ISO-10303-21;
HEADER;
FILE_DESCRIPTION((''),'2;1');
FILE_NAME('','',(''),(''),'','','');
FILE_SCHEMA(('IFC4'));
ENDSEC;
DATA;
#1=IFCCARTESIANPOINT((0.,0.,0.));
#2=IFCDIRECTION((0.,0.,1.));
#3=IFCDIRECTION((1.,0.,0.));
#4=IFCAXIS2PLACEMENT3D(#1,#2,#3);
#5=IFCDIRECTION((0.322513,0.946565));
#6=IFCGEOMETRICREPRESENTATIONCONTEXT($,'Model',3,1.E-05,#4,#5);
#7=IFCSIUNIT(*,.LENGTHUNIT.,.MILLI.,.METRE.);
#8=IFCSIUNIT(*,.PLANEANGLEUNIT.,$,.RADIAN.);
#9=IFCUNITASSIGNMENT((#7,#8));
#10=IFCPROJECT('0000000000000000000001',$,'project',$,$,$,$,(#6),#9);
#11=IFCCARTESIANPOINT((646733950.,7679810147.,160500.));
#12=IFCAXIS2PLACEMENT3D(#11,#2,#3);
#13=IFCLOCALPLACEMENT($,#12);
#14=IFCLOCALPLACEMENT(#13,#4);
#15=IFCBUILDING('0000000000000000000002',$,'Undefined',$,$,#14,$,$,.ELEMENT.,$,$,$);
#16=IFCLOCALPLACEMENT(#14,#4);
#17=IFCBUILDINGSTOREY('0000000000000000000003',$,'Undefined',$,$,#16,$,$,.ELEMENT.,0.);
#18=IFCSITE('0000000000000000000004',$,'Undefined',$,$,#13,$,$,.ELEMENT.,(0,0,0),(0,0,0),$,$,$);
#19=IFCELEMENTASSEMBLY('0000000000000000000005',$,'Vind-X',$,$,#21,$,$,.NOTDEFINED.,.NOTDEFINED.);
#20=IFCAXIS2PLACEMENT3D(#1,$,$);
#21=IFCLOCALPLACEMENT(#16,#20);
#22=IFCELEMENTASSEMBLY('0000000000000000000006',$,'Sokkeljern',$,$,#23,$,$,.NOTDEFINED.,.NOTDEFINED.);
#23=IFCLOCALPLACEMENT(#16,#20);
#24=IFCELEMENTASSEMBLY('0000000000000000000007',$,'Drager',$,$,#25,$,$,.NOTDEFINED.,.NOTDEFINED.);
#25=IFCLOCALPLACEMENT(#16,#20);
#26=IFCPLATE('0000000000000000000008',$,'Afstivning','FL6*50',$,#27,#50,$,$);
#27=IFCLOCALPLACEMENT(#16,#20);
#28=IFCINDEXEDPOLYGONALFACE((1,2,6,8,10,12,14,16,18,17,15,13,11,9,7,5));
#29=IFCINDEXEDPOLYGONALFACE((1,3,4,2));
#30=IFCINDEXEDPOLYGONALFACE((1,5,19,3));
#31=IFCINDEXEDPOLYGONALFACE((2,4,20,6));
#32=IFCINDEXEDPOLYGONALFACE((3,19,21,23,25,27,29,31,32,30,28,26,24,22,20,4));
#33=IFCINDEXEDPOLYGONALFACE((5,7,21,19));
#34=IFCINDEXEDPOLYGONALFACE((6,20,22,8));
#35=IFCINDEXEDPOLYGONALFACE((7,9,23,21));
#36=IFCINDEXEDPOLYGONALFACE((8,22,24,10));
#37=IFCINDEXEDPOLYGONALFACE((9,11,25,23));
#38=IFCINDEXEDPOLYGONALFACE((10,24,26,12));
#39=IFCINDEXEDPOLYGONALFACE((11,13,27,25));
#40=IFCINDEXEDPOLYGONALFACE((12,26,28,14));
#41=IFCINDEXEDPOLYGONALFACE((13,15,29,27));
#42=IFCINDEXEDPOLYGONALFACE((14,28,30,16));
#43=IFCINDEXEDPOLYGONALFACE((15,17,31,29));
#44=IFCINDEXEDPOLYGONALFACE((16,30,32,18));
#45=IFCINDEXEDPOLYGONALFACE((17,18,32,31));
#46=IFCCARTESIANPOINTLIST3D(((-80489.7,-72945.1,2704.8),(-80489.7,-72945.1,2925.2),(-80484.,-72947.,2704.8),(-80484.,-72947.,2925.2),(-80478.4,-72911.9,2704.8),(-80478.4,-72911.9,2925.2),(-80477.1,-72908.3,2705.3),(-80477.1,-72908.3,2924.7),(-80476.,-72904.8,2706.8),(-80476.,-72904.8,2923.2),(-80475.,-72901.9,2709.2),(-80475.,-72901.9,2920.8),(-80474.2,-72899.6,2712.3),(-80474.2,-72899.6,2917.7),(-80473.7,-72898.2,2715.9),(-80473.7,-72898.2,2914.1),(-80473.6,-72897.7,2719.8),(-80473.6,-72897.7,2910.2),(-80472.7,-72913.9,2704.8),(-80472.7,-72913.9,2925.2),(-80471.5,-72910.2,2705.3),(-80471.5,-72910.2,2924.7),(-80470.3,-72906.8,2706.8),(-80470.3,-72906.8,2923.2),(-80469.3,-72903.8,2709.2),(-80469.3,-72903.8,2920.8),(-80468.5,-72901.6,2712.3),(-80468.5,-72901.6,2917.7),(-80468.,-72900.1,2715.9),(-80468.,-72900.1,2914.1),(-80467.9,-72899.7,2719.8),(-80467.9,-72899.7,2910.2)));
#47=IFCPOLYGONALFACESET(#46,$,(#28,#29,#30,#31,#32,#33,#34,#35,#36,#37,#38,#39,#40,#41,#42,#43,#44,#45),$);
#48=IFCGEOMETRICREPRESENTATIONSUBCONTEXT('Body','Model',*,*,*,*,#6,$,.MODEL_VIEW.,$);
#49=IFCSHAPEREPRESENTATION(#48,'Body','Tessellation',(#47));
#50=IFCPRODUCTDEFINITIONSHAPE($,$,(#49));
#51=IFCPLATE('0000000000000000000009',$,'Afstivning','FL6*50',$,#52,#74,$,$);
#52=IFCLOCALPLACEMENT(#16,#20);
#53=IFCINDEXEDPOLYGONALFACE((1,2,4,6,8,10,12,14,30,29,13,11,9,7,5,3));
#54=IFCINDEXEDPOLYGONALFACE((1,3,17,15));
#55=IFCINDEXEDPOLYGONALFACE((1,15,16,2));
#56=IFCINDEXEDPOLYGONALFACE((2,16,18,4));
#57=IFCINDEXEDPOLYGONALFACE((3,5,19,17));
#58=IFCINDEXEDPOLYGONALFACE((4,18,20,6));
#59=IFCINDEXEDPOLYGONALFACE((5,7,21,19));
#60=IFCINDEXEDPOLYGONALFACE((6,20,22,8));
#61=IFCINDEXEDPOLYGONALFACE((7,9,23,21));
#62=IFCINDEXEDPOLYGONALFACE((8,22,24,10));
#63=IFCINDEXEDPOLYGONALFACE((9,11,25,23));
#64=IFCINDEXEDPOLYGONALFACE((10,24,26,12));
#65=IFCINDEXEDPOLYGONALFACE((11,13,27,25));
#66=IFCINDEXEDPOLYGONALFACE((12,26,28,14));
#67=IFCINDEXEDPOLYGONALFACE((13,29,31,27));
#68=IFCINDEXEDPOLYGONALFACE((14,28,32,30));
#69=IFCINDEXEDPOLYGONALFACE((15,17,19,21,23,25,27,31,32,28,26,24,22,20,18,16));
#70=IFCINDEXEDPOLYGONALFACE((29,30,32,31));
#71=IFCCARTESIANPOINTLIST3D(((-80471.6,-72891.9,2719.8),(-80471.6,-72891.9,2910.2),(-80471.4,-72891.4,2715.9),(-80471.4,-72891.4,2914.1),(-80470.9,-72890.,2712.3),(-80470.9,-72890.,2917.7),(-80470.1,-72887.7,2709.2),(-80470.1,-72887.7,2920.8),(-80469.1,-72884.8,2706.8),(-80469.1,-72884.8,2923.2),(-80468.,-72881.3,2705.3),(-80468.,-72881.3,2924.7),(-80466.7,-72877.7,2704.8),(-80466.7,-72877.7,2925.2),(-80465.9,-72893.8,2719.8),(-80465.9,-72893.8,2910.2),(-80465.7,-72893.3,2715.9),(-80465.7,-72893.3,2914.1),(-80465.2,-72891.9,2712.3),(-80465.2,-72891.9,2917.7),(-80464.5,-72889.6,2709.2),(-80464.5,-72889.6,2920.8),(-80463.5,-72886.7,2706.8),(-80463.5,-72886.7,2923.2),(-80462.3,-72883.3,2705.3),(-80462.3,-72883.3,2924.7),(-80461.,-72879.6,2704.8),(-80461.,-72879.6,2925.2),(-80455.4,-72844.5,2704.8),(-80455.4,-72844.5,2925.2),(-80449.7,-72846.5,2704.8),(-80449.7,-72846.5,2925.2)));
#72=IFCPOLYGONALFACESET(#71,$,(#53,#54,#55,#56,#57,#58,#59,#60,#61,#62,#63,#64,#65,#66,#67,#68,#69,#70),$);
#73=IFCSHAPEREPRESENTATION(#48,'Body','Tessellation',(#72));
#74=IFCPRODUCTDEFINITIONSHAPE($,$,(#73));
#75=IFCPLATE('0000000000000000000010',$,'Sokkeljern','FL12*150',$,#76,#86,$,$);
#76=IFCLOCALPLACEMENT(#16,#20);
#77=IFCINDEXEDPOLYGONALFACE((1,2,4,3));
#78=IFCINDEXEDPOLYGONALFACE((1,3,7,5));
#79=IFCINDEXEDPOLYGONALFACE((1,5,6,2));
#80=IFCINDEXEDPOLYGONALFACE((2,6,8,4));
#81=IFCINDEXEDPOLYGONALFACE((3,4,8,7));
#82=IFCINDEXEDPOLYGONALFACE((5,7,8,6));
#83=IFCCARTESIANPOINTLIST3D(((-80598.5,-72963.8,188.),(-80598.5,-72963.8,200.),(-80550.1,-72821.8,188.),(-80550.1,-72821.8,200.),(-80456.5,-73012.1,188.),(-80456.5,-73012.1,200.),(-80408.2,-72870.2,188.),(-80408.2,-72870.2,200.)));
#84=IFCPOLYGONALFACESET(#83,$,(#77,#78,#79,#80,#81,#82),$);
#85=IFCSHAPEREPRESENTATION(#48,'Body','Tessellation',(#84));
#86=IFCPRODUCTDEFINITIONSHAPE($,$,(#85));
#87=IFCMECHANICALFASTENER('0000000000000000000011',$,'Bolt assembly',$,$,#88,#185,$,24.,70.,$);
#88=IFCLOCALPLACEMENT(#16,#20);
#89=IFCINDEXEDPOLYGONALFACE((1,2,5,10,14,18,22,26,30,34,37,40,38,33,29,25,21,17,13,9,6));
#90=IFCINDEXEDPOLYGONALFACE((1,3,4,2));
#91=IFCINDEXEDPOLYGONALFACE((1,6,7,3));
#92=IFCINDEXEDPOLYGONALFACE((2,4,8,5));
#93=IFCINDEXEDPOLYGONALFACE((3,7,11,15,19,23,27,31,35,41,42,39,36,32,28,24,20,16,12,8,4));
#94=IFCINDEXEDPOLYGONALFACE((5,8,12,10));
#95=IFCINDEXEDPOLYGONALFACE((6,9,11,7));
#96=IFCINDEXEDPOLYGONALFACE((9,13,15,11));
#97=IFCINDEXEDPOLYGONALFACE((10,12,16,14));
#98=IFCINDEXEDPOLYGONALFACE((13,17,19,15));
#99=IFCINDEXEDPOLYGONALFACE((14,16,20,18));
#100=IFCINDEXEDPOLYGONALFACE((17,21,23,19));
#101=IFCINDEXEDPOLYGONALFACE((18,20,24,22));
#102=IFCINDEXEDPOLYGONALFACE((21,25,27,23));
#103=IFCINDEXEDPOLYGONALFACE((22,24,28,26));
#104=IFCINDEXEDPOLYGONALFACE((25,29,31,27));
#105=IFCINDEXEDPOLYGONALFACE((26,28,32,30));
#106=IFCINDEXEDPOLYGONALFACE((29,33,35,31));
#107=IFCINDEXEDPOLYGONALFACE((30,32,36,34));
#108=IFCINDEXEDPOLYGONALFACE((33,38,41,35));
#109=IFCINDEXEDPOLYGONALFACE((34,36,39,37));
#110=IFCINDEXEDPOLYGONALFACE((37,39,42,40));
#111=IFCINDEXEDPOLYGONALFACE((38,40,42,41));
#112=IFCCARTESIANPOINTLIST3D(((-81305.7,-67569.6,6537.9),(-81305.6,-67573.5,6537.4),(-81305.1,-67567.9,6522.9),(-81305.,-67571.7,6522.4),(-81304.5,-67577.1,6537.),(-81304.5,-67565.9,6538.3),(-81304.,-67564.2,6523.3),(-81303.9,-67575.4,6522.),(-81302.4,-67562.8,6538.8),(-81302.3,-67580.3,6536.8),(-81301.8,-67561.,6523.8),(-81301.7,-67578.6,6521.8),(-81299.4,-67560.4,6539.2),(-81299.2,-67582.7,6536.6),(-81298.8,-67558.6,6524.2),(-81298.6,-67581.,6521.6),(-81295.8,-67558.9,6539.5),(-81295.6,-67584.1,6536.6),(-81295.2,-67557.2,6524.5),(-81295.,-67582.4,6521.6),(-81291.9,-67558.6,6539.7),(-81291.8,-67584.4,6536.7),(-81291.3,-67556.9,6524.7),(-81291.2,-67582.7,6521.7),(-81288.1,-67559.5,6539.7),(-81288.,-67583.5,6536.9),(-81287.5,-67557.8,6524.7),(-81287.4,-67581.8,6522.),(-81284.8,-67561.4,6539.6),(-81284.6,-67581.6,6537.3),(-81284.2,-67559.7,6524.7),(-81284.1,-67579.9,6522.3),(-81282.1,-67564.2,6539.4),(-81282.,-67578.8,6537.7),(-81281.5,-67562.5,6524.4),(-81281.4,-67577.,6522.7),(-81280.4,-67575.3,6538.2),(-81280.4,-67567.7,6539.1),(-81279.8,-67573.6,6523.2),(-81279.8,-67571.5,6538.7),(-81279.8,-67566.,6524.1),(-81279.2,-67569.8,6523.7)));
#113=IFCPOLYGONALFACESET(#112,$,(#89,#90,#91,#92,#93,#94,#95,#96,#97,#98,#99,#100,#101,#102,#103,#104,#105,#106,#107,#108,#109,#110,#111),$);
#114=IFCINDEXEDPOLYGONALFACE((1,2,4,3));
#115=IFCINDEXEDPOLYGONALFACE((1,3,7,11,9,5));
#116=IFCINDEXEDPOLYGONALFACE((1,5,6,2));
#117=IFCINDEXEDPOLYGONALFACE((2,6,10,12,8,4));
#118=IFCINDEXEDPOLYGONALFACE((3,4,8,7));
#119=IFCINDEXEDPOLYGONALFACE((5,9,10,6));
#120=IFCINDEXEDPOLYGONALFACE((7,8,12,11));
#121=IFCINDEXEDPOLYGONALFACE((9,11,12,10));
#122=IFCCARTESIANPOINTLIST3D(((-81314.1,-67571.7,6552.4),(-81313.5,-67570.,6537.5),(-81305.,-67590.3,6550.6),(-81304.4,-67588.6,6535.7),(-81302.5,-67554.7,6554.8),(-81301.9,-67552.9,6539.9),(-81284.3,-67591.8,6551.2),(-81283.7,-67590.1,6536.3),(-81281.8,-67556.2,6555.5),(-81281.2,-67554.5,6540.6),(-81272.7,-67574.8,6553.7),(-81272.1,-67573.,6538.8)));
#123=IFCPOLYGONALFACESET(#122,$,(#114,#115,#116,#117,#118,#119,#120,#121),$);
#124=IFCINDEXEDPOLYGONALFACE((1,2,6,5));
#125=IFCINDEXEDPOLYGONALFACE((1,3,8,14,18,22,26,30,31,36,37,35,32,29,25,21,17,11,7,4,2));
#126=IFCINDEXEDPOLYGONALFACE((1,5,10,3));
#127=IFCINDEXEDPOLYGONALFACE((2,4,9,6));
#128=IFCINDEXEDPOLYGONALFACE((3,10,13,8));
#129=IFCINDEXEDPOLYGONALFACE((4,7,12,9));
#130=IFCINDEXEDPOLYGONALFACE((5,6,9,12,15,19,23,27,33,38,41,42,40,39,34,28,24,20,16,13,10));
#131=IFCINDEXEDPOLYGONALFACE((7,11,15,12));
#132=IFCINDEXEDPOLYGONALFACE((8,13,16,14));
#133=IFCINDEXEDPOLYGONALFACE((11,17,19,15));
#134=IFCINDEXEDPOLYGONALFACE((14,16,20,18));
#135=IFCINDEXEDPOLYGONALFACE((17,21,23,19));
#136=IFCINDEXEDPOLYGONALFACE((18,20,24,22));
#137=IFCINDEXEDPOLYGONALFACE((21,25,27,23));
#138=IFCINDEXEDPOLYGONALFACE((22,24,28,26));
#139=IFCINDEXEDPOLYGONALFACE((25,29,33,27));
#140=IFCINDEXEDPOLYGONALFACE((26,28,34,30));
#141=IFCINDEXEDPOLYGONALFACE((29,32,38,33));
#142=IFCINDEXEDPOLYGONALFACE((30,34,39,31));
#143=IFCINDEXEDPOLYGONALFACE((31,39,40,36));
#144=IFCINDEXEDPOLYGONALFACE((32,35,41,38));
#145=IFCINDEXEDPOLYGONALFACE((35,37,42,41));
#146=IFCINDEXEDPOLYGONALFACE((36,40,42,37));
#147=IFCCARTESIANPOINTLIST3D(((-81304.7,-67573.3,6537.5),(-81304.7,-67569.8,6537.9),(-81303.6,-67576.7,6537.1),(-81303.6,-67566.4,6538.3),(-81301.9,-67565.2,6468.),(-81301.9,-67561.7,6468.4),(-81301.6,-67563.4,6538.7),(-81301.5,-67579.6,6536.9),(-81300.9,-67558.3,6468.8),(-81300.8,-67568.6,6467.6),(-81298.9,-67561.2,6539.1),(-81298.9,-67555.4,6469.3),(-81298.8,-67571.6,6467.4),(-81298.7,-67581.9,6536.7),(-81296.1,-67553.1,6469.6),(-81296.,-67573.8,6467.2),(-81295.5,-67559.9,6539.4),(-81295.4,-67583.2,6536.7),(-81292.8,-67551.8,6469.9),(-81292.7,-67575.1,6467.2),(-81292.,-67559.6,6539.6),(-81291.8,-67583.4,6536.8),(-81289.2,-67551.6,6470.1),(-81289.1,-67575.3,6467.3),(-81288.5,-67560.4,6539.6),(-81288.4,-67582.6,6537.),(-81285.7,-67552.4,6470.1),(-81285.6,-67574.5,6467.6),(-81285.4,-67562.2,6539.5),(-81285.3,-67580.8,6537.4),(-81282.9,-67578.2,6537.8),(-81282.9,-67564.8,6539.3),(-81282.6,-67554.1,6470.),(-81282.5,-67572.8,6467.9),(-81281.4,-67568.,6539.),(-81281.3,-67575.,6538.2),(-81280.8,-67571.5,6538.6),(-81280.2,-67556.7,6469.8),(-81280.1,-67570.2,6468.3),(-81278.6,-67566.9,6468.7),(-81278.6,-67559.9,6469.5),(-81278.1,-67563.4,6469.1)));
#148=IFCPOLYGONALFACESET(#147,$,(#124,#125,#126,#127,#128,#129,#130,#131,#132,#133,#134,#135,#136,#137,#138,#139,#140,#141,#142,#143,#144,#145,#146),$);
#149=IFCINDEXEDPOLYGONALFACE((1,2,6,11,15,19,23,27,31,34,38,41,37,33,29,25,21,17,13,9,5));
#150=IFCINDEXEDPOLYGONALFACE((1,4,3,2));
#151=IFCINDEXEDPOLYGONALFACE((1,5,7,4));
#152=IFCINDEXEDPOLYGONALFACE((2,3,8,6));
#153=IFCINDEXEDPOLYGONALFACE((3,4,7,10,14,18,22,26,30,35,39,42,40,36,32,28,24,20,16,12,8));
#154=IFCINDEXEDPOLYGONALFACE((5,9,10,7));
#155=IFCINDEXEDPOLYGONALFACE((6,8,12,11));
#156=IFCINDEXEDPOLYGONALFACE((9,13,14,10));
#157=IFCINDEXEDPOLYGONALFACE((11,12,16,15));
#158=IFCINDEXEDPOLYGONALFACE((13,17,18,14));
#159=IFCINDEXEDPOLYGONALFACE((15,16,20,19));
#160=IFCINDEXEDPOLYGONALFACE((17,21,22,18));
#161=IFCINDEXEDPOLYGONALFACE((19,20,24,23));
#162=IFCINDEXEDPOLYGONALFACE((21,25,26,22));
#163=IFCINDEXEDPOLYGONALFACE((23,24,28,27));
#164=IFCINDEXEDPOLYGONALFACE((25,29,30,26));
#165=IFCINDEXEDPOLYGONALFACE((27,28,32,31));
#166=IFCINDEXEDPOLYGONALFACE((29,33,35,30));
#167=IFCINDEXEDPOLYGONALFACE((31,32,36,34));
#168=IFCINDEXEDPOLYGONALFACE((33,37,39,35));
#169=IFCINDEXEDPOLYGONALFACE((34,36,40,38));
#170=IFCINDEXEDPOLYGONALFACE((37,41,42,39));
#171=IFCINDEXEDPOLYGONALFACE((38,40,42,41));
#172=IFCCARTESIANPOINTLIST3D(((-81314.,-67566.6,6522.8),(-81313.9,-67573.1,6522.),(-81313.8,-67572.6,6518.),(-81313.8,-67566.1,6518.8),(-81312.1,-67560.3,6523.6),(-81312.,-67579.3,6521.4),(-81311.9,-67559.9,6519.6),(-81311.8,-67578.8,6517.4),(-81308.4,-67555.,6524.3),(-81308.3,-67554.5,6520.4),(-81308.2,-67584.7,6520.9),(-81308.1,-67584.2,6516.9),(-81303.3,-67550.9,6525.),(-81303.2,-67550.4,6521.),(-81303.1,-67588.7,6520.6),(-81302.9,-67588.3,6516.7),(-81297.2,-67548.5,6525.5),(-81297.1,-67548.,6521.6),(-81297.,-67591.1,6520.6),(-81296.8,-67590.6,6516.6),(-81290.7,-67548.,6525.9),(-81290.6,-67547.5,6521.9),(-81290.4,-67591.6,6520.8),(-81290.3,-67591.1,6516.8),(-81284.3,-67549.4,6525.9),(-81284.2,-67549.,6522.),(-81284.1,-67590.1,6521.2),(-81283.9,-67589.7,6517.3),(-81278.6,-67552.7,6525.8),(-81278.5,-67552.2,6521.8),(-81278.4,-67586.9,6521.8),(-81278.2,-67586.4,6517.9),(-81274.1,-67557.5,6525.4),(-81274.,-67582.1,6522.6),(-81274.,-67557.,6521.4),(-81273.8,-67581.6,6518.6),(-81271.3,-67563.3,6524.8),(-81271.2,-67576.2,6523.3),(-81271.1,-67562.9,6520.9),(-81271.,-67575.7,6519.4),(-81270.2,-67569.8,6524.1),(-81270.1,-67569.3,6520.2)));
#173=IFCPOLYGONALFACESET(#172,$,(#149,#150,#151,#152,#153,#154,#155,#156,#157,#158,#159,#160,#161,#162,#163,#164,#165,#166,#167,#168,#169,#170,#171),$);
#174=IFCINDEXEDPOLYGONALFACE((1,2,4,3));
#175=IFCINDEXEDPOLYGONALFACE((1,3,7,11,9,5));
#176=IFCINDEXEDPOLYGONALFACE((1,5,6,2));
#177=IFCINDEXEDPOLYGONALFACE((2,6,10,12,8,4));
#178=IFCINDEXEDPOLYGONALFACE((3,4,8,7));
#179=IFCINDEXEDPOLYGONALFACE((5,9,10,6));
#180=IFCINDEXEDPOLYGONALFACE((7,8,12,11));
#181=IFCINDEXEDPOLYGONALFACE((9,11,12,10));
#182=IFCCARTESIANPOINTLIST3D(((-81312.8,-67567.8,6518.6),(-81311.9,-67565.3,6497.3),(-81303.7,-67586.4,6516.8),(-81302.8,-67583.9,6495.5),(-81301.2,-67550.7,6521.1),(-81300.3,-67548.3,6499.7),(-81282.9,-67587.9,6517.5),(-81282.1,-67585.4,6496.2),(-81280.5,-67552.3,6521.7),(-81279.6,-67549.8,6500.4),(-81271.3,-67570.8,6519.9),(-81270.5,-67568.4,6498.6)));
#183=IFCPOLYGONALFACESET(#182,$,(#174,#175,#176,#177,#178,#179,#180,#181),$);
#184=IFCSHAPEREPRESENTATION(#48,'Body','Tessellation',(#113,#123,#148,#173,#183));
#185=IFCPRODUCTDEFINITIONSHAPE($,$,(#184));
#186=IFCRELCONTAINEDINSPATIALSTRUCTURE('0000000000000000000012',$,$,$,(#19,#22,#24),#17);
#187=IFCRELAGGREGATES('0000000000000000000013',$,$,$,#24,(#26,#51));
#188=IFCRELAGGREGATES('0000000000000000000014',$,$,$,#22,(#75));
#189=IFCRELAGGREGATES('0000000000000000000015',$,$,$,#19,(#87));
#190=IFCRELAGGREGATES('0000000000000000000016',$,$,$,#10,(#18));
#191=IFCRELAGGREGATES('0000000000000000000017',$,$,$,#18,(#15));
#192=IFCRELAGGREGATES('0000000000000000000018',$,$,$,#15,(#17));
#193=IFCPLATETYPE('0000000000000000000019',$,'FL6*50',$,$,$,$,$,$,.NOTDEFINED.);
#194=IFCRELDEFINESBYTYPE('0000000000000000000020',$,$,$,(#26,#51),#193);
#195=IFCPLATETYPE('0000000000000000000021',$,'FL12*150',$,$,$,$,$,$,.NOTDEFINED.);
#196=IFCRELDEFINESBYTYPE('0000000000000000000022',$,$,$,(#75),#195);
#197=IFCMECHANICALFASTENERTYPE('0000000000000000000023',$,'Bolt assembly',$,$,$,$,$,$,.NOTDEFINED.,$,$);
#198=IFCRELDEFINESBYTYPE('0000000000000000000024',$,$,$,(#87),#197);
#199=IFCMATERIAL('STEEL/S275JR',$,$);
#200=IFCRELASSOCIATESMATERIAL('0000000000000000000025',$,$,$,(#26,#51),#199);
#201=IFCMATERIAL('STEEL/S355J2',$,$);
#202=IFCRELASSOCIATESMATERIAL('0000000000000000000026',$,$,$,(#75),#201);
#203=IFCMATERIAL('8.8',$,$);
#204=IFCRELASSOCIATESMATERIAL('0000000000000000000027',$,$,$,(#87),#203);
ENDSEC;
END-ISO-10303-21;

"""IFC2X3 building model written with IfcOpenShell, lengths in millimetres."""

from ifc_helpers import new_model, si_unit, direction, frame, frame_2d, origin_with_axes, origin_2d_with_axis, place, context, subcontext, project, spatial, polyline, circle_curve, parameter, trimmed, segment, composite_curve, circle, outline, extrude, source, transform, mapped, material, type_object, element, aggregate, save


model = new_model("IFC2X3")

# Units and contexts
model_context = context("Model", 3, precision=1e-05, world=origin_with_axes(), true_north=direction((0.322513, 0.946565)))
body_context = subcontext(model_context, "Body", "Model", "MODEL_VIEW")
ifc_project = project(units=[si_unit("LENGTHUNIT", "METRE", prefix="MILLI"), si_unit("PLANEANGLEUNIT", "RADIAN")], contexts=[model_context])

# Site, building, storey
site_placement = place(None, frame((646733950.0, 7679810147.0, 160500.0), z_axis=(0.0, 0.0, 1.0), x_axis=(1.0, 0.0, 0.0)))
site = spatial("IfcSite", under=ifc_project, at=site_placement, Name="Undefined", CompositionType="ELEMENT", RefLatitude=(0, 0, 0), RefLongitude=(0, 0, 0))
building_placement = place(site_placement, origin_with_axes())
building = spatial("IfcBuilding", under=site, at=building_placement, Name="Undefined", CompositionType="ELEMENT")
storey_placement = place(building_placement, origin_with_axes())
storey = spatial("IfcBuildingStorey", under=building, at=storey_placement, Name="Undefined", CompositionType="ELEMENT", Elevation=0.0)

# Element assembly
assembly_1_placement = place(storey_placement, origin_with_axes())
assembly_1 = element("IfcElementAssembly", 1, at=assembly_1_placement, inside=storey, Name="Vind-X", AssemblyPlace="NOTDEFINED", PredefinedType="NOTDEFINED")
ifc_material_1 = material(Name="STEEL/S355J2")

# Element assembly
assembly_2_placement = place(storey_placement, origin_with_axes())
assembly_2 = element("IfcElementAssembly", 2, at=assembly_2_placement, inside=storey, Name="Sokkeljern", AssemblyPlace="NOTDEFINED", PredefinedType="NOTDEFINED")

# Shared definitions
ifc_material_2 = material(Name="STEEL/S275JR")

# Element assembly, plates
assembly_3_placement = place(storey_placement, origin_with_axes())
assembly_3 = element("IfcElementAssembly", 3, at=assembly_3_placement, inside=storey, Name="Drager", AssemblyPlace="NOTDEFINED", PredefinedType="NOTDEFINED")
plate_type_1 = type_object("IfcPlateType", Name="FL6*50", PredefinedType="NOTDEFINED")
plate_1_placement = place(assembly_3_placement, frame((-80470.7, -72898.7, 2704.8), z_axis=(-0.946565, 0.322513, 0.0), x_axis=(-0.322513, -0.946565, 0.0)))
plate_1 = element("IfcPlate", 4, at=plate_1_placement, type_object=plate_type_1, material=ifc_material_2, Name="Afstivning", Description="FL6*50", context=body_context, shape_type="SweptSolid", body=[
    extrude(outline(composite_curve([segment(trimmed(circle_curve(frame_2d((15.0, 15.0), x_axis=(-1.0, 0.0)), 15.0), [parameter(0.0)], [parameter(1.570796)], True, "PARAMETER"), True, "CONTINUOUS"), segment(polyline([(15.0, 0.0), (50.0, 0.0), (50.0, 220.4), (15.0, 220.4)]), True, "CONTINUOUS"), segment(trimmed(circle_curve(frame_2d((15.0, 205.4), x_axis=(0.0, 1.0)), 15.0), [parameter(0.0)], [parameter(1.570796)], True, "PARAMETER"), True, "CONTINUOUS"), segment(polyline([(0.0, 205.4), (0.0, 15.0)]), True, "CONTINUOUS")], self_intersect=True)), frame((0.0, 0.0, -3.0), z_axis=(0.0, 0.0, 1.0), x_axis=(1.0, 0.0, 0.0)), (0.0, 0.0, 1.0), 6.0),
])
plate_2_placement = place(assembly_3_placement, frame((-80452.6, -72845.5, 2704.8), z_axis=(-0.946565, 0.322513, 0.0), x_axis=(-0.322513, -0.946565, 0.0)))
plate_2 = element("IfcPlate", 5, at=plate_2_placement, type_object=plate_type_1, material=ifc_material_2, Name="Afstivning", Description="FL6*50", context=body_context, shape_type="SweptSolid", body=[
    extrude(outline(composite_curve([segment(polyline([(0.0, 0.0), (35.0, 0.0)]), True, "CONTINUOUS"), segment(trimmed(circle_curve(frame_2d((35.0, 15.0), x_axis=(0.0, -1.0)), 15.0), [parameter(0.0)], [parameter(1.570796)], True, "PARAMETER"), True, "CONTINUOUS"), segment(polyline([(50.0, 15.0), (50.0, 205.4)]), True, "CONTINUOUS"), segment(trimmed(circle_curve(frame_2d((35.0, 205.4), x_axis=(1.0, 0.0)), 15.0), [parameter(0.0)], [parameter(1.570796)], True, "PARAMETER"), True, "CONTINUOUS"), segment(polyline([(35.0, 220.4), (0.0, 220.4), (0.0, 0.0)]), True, "CONTINUOUS")], self_intersect=True)), frame((0.0, 0.0, -3.0), z_axis=(0.0, 0.0, 1.0), x_axis=(1.0, 0.0, 0.0)), (0.0, 0.0, 1.0), 6.0),
])
aggregate(assembly_3, [plate_1, plate_2])

# Plate
plate_type_2 = type_object("IfcPlateType", Name="FL12*150", PredefinedType="NOTDEFINED")
plate_3_placement = place(assembly_2_placement, frame((-80550.1, -72821.8, 194.0), z_axis=(0.0, 0.0, 1.0), x_axis=(-0.322513, -0.946565, 0.0)))
plate_3 = element("IfcPlate", 6, at=plate_3_placement, type_object=plate_type_2, material=ifc_material_1, Name="Sokkeljern", Description="FL12*150", context=body_context, shape_type="SweptSolid", body=[
    extrude(outline(polyline([(0.0, 0.0), (150.0, 0.0), (150.0, 150.0), (0.0, 150.0), (0.0, 0.0)])), frame((0.0, 0.0, -6.0), z_axis=(0.0, 0.0, 1.0), x_axis=(1.0, 0.0, 0.0)), (0.0, 0.0, 1.0), 12.0),
])
aggregate(assembly_2, [plate_3])

# Mechanical fastener
ifc_material_3 = material(Name="8.8")
mechanical_fastener_type = type_object("IfcMechanicalFastenerType", Name="Bolt assembly")
shared_shape_1 = source(origin_with_axes(), body_context, "Body", "SweptSolid", [
    extrude(circle(Radius=13.0, at=origin_2d_with_axis()), frame((0.0, 0.0, 0.0), z_axis=(0.0, 1.0, 0.0), x_axis=(1.0, 0.0, 0.0)), (0.0, 0.0, 1.0), 15.1),
    extrude(outline(polyline([(18.0, -10.4), (18.0, 10.4), (0.0, 20.8), (-18.0, 10.4), (-18.0, -10.4), (0.0, -20.8), (18.0, -10.4)])), frame((0.0, -15.0, 0.0), z_axis=(0.0, 1.0, 0.0), x_axis=(1.0, 0.0, 0.0)), (0.0, 0.0, 1.0), 15.0),
    extrude(circle(Radius=12.0, at=origin_2d_with_axis()), frame((0.0, 0.0, 0.0), z_axis=(0.0, 1.0, 0.0), x_axis=(1.0, 0.0, 0.0)), (0.0, 0.0, 1.0), 70.0),
    extrude(circle(Radius=22.0, at=origin_2d_with_axis()), frame((0.0, 15.0, 0.0), z_axis=(0.0, 1.0, 0.0), x_axis=(1.0, 0.0, 0.0)), (0.0, 0.0, 1.0), 4.0),
    extrude(outline(polyline([(18.0, -10.4), (18.0, 10.4), (0.0, 20.8), (-18.0, 10.4), (-18.0, -10.4), (0.0, -20.8), (18.0, -10.4)])), frame((0.0, 19.0, 0.0), z_axis=(0.0, 1.0, 0.0), x_axis=(1.0, 0.0, 0.0)), (0.0, 0.0, 1.0), 21.5),
])
mechanical_fastener_1_placement = place(assembly_1_placement, frame((-81292.8, -67571.5, 6538.1), z_axis=(0.439079, -0.89427, -0.086548), x_axis=(-0.897588, -0.432405, -0.0858)))
mechanical_fastener_1 = element("IfcMechanicalFastener", 7, at=mechanical_fastener_1_placement, type_object=mechanical_fastener_type, material=ifc_material_3, Name="Bolt assembly", NominalDiameter=24.0, NominalLength=70.0, context=body_context, shape_type="MappedRepresentation", body=[
    mapped(shared_shape_1, transform((0.0, 0.0, 0.0))),
])
aggregate(assembly_1, [mechanical_fastener_1])

save(model, "model.ifc")
